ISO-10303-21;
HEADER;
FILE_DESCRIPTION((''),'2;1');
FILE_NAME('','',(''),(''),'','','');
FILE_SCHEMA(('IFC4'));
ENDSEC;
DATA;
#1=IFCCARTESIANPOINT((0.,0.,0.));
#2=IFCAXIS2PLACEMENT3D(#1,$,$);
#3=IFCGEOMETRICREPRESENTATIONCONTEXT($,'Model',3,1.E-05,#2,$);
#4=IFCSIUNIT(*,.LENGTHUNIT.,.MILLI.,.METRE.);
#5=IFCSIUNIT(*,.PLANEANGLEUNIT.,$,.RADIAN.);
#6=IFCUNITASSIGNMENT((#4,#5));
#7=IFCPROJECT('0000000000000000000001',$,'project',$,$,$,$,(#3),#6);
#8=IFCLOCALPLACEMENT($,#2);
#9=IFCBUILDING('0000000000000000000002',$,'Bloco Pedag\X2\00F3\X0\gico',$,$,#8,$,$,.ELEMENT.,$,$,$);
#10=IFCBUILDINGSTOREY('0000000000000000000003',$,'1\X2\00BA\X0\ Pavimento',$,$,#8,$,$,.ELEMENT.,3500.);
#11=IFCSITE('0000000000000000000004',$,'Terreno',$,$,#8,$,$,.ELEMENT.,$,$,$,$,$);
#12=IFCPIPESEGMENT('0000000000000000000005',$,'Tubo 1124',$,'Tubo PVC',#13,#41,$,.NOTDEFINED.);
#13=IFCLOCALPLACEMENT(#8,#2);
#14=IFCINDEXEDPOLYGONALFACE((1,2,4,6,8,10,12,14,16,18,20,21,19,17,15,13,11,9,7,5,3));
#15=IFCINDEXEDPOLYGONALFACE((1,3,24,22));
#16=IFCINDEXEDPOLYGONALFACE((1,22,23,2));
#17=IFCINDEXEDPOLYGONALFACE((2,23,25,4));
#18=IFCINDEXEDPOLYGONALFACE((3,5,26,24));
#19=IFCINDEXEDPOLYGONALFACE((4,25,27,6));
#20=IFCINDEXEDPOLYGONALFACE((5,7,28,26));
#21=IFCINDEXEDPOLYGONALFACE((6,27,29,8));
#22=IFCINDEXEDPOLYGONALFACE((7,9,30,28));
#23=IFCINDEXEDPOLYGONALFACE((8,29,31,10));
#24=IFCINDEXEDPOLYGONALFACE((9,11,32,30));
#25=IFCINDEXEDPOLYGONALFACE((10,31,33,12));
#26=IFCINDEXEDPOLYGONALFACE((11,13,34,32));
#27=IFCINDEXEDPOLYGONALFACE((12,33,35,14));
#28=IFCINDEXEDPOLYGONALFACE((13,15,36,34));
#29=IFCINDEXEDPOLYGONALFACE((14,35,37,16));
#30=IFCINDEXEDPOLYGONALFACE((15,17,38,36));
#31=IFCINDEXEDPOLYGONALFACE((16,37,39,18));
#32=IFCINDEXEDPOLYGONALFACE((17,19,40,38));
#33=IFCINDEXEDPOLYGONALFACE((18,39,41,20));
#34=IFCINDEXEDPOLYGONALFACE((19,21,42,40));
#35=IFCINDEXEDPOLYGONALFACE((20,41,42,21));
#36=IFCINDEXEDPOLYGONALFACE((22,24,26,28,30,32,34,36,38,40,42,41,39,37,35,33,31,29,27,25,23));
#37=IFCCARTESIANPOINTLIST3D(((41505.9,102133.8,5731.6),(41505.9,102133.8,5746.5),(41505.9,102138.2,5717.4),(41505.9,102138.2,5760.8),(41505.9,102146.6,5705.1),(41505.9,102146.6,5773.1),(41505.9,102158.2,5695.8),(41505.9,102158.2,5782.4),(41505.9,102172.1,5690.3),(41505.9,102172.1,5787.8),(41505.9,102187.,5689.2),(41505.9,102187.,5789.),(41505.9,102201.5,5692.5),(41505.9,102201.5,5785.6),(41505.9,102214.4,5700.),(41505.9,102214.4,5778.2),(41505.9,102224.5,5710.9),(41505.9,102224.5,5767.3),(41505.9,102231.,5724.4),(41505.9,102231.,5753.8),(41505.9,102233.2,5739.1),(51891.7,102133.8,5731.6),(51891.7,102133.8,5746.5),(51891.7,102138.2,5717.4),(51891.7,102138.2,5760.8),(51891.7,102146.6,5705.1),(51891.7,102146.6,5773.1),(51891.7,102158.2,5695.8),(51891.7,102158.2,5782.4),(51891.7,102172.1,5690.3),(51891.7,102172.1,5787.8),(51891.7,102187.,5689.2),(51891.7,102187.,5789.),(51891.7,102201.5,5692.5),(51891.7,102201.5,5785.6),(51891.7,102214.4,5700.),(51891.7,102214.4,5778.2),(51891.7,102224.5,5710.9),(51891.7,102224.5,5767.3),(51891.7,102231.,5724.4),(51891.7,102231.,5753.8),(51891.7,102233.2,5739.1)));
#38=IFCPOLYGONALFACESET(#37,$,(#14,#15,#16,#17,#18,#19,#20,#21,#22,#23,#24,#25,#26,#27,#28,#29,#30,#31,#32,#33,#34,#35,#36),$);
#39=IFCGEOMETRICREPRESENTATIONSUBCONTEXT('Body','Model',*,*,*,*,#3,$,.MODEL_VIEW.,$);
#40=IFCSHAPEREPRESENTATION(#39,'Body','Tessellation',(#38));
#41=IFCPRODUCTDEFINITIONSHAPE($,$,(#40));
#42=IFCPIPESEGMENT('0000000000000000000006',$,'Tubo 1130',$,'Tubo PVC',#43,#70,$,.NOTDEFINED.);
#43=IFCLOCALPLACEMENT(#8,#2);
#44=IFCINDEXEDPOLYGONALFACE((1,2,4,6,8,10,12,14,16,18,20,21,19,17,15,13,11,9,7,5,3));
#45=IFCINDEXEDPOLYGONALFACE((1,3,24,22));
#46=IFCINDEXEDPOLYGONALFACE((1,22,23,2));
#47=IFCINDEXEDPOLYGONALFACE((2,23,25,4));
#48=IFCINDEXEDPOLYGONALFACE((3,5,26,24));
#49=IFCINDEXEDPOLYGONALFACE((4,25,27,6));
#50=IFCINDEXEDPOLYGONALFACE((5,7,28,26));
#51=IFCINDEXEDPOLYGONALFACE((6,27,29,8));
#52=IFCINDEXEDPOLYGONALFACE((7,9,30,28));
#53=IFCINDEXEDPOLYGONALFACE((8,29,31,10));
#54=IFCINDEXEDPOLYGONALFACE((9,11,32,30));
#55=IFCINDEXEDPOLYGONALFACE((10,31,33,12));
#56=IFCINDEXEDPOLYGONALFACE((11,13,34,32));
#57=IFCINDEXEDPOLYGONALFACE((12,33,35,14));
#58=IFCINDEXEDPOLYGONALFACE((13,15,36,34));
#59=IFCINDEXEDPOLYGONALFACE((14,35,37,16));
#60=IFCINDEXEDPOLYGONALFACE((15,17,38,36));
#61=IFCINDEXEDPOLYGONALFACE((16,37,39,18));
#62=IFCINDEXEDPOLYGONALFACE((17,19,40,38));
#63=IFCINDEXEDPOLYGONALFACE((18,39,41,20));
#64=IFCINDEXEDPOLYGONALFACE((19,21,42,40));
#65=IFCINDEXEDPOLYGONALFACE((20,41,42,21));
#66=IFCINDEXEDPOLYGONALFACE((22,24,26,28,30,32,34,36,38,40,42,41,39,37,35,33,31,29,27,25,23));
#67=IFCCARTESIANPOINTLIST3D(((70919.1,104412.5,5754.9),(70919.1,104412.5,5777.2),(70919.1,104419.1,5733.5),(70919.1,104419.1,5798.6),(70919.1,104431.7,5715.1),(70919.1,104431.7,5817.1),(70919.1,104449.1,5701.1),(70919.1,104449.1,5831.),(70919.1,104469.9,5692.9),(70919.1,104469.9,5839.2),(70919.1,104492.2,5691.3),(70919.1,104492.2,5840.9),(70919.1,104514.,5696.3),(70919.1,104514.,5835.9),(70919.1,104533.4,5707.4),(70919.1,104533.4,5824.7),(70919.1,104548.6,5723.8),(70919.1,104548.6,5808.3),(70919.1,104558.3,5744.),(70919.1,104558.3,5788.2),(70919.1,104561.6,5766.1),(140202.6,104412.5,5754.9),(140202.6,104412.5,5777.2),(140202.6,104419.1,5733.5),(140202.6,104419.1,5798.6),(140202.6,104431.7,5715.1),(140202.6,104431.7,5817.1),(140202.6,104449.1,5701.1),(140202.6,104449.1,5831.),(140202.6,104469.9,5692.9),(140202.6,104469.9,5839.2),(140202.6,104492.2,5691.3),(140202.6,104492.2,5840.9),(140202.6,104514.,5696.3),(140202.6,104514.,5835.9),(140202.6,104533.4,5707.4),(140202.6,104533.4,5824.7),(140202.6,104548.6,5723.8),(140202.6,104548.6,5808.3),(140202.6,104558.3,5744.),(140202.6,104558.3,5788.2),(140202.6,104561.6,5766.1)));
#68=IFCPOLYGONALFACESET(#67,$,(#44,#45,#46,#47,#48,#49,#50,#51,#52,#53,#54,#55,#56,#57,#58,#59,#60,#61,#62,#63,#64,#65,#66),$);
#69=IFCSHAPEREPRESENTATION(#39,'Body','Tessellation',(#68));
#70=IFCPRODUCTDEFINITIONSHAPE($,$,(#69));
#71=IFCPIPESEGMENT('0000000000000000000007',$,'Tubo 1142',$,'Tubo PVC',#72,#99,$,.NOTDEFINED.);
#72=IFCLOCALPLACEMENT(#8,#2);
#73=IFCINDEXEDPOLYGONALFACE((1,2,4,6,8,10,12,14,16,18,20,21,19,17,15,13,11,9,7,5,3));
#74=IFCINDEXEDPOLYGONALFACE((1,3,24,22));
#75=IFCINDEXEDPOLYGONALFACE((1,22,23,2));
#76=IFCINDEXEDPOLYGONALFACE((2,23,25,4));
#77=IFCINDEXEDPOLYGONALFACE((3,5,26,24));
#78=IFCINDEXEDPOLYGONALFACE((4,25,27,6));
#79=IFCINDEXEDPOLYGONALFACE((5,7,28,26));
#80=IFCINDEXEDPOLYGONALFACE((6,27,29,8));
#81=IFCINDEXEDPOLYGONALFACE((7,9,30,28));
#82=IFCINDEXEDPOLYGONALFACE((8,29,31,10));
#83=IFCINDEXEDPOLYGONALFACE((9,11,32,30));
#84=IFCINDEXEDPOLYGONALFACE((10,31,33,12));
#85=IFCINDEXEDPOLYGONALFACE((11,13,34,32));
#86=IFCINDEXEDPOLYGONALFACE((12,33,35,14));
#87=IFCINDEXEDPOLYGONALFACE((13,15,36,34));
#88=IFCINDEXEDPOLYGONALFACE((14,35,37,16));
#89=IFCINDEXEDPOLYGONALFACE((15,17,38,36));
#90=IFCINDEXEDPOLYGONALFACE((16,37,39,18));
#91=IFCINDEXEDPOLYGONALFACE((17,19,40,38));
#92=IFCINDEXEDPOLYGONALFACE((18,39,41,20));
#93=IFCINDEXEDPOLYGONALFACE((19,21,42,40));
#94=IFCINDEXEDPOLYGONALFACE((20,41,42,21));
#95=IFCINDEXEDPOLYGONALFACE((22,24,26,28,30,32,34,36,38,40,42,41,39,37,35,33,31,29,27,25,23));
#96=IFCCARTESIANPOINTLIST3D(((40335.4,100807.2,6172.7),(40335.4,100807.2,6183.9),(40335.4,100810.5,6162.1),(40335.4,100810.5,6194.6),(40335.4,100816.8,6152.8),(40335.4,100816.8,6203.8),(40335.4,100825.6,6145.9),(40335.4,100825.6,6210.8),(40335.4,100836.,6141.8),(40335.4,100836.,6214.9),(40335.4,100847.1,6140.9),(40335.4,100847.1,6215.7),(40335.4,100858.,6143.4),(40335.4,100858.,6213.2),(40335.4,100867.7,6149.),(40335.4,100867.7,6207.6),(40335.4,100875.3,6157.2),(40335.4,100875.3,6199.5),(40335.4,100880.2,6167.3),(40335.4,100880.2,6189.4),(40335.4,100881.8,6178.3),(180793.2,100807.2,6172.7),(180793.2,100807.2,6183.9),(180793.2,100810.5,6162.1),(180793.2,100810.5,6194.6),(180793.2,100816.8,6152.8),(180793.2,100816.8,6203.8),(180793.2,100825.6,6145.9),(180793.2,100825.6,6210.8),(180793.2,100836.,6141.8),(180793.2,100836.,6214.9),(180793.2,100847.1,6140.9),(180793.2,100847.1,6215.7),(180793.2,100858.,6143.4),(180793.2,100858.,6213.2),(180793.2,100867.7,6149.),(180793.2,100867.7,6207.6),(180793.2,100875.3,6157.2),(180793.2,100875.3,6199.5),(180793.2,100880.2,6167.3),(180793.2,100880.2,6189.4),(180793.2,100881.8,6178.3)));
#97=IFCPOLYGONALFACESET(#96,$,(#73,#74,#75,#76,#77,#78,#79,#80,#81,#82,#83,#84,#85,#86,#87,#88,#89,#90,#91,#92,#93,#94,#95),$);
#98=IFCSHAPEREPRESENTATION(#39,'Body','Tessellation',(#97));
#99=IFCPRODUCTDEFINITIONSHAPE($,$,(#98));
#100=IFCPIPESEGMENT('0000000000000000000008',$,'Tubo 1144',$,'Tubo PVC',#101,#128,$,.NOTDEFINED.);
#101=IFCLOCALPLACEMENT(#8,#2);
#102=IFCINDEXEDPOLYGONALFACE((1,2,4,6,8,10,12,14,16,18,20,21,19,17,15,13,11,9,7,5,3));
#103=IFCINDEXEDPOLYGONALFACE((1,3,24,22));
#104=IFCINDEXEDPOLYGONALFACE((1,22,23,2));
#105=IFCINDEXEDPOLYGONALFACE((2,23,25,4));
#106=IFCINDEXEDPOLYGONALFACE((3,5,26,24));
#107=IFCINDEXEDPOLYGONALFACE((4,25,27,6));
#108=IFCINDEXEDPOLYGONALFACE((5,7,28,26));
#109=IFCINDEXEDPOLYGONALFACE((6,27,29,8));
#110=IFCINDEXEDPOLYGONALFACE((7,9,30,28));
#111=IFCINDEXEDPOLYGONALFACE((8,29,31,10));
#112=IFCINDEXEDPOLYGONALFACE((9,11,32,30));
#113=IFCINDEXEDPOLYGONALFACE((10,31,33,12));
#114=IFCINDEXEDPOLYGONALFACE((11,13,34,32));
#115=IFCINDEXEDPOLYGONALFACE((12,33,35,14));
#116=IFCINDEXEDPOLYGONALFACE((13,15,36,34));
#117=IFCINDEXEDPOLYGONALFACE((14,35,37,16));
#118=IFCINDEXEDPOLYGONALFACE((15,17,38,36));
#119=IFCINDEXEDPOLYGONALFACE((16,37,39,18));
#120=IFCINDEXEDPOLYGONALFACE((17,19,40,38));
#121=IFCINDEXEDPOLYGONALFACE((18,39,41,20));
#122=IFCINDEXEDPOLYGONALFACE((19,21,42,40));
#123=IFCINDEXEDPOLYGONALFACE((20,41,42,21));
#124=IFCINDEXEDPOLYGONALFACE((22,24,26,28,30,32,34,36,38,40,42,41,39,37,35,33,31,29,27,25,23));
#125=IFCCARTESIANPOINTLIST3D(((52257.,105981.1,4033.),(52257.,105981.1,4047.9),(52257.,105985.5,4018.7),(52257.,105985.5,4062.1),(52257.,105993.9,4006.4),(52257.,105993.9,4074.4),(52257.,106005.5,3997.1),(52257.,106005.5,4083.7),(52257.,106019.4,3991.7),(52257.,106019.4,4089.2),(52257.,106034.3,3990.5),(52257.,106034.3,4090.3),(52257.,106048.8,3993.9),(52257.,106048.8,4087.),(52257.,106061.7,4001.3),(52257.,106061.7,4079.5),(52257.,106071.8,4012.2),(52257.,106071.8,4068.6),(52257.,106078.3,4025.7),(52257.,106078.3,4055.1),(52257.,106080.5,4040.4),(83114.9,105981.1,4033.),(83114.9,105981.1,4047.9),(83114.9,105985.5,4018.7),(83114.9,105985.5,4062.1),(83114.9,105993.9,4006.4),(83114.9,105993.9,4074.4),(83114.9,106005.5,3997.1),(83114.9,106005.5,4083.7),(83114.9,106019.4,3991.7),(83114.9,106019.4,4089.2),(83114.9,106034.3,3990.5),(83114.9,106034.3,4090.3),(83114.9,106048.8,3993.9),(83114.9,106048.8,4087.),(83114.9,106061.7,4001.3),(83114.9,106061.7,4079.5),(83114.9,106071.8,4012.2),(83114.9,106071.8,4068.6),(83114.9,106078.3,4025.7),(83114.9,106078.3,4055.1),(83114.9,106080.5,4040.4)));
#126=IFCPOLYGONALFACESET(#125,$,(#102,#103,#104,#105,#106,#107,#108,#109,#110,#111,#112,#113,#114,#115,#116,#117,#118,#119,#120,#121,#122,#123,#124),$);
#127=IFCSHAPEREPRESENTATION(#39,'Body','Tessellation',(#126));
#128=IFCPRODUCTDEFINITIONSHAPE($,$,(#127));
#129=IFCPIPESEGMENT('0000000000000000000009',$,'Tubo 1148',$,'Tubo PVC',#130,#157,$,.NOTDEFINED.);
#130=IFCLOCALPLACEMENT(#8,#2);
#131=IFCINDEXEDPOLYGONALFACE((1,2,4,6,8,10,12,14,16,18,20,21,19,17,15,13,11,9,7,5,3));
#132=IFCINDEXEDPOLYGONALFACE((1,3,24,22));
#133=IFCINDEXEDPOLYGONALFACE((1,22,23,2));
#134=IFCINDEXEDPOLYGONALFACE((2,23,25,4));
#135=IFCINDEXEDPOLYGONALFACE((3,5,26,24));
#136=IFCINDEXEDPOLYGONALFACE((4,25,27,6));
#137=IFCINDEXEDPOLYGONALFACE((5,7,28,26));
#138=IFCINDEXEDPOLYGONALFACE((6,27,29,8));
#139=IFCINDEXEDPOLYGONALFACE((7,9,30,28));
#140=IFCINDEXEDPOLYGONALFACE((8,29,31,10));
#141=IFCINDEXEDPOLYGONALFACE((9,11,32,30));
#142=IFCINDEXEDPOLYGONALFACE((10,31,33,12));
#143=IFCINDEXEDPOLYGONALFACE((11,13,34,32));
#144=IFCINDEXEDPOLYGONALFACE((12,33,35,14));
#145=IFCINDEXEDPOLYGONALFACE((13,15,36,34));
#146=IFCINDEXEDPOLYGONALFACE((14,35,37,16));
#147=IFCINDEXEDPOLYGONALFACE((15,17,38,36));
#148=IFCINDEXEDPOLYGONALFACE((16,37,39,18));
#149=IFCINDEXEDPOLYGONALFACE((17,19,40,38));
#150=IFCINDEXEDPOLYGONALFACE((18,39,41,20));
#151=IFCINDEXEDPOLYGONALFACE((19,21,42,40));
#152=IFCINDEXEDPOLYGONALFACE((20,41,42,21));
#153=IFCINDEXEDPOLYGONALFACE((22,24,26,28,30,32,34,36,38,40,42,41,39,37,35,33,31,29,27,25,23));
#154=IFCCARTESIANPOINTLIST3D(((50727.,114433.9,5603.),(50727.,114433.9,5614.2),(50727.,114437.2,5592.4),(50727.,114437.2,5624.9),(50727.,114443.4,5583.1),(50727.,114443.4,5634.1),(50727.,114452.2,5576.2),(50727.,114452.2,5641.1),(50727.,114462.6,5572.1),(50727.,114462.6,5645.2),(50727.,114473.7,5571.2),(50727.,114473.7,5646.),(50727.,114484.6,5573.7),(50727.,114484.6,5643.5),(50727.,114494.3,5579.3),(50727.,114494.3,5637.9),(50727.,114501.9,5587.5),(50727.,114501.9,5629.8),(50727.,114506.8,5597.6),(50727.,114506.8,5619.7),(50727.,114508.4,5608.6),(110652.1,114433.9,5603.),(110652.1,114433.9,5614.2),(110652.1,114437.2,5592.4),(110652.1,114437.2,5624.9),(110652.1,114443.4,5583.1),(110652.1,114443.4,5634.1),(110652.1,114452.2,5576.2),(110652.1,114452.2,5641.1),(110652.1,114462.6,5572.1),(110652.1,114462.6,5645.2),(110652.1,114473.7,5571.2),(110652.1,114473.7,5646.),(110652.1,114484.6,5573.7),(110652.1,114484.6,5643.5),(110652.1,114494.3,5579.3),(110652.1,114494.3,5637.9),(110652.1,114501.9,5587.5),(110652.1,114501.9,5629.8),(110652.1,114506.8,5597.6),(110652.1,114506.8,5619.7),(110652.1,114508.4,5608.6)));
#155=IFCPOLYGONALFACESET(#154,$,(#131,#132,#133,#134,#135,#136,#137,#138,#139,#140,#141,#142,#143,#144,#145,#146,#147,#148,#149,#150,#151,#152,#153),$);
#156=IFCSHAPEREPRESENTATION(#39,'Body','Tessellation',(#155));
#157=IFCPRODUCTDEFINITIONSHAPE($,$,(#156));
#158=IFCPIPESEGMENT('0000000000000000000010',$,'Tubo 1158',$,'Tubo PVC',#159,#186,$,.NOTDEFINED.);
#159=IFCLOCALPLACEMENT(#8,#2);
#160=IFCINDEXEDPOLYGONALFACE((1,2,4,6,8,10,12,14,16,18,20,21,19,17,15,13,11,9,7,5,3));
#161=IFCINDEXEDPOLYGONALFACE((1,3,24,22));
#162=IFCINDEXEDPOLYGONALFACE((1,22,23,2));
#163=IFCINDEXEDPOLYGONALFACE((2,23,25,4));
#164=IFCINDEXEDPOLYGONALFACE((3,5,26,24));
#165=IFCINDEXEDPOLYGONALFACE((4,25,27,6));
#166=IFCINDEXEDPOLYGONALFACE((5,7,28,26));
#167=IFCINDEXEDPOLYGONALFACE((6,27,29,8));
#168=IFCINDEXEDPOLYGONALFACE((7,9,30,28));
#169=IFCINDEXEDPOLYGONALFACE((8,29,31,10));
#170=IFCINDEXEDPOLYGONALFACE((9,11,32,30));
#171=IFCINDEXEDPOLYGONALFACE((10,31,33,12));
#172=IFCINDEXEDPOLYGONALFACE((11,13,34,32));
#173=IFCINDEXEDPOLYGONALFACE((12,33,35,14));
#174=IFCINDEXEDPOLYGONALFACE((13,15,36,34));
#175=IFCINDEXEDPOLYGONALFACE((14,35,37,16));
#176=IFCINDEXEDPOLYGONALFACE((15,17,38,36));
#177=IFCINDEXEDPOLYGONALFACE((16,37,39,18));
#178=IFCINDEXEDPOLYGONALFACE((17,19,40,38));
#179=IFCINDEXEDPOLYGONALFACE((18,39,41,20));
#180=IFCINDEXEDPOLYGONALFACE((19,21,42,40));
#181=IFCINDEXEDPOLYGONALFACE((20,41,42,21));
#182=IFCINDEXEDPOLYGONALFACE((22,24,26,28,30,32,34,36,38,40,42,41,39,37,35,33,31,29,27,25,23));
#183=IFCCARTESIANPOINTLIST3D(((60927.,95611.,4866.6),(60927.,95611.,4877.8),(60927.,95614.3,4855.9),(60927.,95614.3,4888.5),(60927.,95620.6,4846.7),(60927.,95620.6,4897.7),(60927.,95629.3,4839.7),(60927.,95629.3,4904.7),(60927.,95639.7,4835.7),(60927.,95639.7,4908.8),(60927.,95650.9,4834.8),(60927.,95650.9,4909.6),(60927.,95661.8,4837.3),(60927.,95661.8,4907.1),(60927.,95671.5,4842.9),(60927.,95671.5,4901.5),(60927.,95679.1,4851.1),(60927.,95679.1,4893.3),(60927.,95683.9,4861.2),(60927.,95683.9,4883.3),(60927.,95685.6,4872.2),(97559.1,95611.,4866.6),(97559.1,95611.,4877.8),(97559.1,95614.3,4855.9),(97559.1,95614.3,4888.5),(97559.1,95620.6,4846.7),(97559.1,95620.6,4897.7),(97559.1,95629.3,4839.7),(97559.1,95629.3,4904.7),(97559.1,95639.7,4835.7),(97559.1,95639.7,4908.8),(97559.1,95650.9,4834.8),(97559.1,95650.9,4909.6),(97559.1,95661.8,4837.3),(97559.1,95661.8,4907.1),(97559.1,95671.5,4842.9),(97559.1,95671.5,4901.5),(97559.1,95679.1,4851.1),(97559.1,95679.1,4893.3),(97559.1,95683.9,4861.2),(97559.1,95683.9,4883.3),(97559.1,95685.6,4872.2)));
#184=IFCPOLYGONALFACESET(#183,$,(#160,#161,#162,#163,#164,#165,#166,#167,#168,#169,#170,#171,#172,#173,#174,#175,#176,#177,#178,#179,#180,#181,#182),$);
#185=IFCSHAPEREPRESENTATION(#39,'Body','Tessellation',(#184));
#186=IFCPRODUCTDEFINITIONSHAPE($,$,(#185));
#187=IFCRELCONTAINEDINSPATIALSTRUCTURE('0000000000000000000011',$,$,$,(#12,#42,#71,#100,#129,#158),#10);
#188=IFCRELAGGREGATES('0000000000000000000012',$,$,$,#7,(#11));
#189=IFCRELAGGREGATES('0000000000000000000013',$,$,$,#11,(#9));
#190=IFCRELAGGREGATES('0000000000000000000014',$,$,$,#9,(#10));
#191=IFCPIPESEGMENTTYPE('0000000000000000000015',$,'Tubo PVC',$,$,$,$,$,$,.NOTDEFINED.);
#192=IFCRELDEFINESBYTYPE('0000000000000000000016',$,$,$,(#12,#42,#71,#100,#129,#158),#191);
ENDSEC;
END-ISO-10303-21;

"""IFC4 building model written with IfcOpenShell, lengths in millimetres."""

from ifc_helpers import new_model, si_unit, frame, origin, origin_2d, place, context, subcontext, project, spatial, circle, extrude, type_object, element, save


model = new_model("IFC4")

# Units and contexts
model_context = context("Model", 3, precision=1e-05, world=origin())
body_context = subcontext(model_context, "Body", "Model", "MODEL_VIEW")
ifc_project = project(units=[si_unit("LENGTHUNIT", "METRE", prefix="MILLI"), si_unit("PLANEANGLEUNIT", "RADIAN")], contexts=[model_context])

# Site, building, storey
placement = place(None, origin())
site = spatial("IfcSite", under=ifc_project, at=placement, Name="Terreno", CompositionType="ELEMENT")
building = spatial("IfcBuilding", under=site, at=placement, Name="Bloco Pedagógico", CompositionType="ELEMENT")
storey = spatial("IfcBuildingStorey", under=building, at=placement, Name="1º Pavimento", CompositionType="ELEMENT", Elevation=3500.0)

# Pipe segments
pipe_segment_type = type_object("IfcPipeSegmentType", Name="Tubo PVC", PredefinedType="NOTDEFINED")
pipe_segment_1_placement = place(None, frame((41505.9, 102183.2, 5739.1), z_axis=(1.0, 0.0, 0.0), x_axis=(0.0, 1.0, 0.0)))
element("IfcPipeSegment", 1, at=pipe_segment_1_placement, inside=storey, type_object=pipe_segment_type, Name="Tubo 1124", ObjectType="Tubo PVC", PredefinedType="NOTDEFINED", context=body_context, shape_type="SweptSolid", body=[
    extrude(circle(Radius=50.0, at=origin_2d()), None, (0.0, 0.0, 1.0), 10385.9),
])
pipe_segment_2_placement = place(None, frame((70919.1, 104486.6, 5766.1), z_axis=(1.0, 0.0, 0.0), x_axis=(0.0, 1.0, 0.0)))
element("IfcPipeSegment", 2, at=pipe_segment_2_placement, inside=storey, type_object=pipe_segment_type, Name="Tubo 1130", ObjectType="Tubo PVC", PredefinedType="NOTDEFINED", context=body_context, shape_type="SweptSolid", body=[
    extrude(circle(Radius=75.0, at=origin_2d()), None, (0.0, 0.0, 1.0), 69283.6),
])
pipe_segment_3_placement = place(None, frame((40335.4, 100844.3, 6178.3), z_axis=(1.0, 0.0, 0.0), x_axis=(0.0, 1.0, 0.0)))
element("IfcPipeSegment", 3, at=pipe_segment_3_placement, inside=storey, type_object=pipe_segment_type, Name="Tubo 1142", ObjectType="Tubo PVC", PredefinedType="NOTDEFINED", context=body_context, shape_type="SweptSolid", body=[
    extrude(circle(Radius=37.5, at=origin_2d()), None, (0.0, 0.0, 1.0), 140457.9),
])
pipe_segment_4_placement = place(None, frame((52257.0, 106030.5, 4040.4), z_axis=(1.0, 0.0, 0.0), x_axis=(0.0, 1.0, 0.0)))
element("IfcPipeSegment", 4, at=pipe_segment_4_placement, inside=storey, type_object=pipe_segment_type, Name="Tubo 1144", ObjectType="Tubo PVC", PredefinedType="NOTDEFINED", context=body_context, shape_type="SweptSolid", body=[
    extrude(circle(Radius=50.0, at=origin_2d()), None, (0.0, 0.0, 1.0), 30857.9),
])
pipe_segment_5_placement = place(None, frame((50727.0, 114470.9, 5608.6), z_axis=(1.0, 0.0, 0.0), x_axis=(0.0, 1.0, 0.0)))
element("IfcPipeSegment", 5, at=pipe_segment_5_placement, inside=storey, type_object=pipe_segment_type, Name="Tubo 1148", ObjectType="Tubo PVC", PredefinedType="NOTDEFINED", context=body_context, shape_type="SweptSolid", body=[
    extrude(circle(Radius=37.5, at=origin_2d()), None, (0.0, 0.0, 1.0), 59925.1),
])
pipe_segment_6_placement = place(None, frame((60927.0, 95648.1, 4872.2), z_axis=(1.0, 0.0, 0.0), x_axis=(0.0, 1.0, 0.0)))
element("IfcPipeSegment", 6, at=pipe_segment_6_placement, inside=storey, type_object=pipe_segment_type, Name="Tubo 1158", ObjectType="Tubo PVC", PredefinedType="NOTDEFINED", context=body_context, shape_type="SweptSolid", body=[
    extrude(circle(Radius=37.5, at=origin_2d()), None, (0.0, 0.0, 1.0), 36632.1),
])

save(model, "model.ifc")
